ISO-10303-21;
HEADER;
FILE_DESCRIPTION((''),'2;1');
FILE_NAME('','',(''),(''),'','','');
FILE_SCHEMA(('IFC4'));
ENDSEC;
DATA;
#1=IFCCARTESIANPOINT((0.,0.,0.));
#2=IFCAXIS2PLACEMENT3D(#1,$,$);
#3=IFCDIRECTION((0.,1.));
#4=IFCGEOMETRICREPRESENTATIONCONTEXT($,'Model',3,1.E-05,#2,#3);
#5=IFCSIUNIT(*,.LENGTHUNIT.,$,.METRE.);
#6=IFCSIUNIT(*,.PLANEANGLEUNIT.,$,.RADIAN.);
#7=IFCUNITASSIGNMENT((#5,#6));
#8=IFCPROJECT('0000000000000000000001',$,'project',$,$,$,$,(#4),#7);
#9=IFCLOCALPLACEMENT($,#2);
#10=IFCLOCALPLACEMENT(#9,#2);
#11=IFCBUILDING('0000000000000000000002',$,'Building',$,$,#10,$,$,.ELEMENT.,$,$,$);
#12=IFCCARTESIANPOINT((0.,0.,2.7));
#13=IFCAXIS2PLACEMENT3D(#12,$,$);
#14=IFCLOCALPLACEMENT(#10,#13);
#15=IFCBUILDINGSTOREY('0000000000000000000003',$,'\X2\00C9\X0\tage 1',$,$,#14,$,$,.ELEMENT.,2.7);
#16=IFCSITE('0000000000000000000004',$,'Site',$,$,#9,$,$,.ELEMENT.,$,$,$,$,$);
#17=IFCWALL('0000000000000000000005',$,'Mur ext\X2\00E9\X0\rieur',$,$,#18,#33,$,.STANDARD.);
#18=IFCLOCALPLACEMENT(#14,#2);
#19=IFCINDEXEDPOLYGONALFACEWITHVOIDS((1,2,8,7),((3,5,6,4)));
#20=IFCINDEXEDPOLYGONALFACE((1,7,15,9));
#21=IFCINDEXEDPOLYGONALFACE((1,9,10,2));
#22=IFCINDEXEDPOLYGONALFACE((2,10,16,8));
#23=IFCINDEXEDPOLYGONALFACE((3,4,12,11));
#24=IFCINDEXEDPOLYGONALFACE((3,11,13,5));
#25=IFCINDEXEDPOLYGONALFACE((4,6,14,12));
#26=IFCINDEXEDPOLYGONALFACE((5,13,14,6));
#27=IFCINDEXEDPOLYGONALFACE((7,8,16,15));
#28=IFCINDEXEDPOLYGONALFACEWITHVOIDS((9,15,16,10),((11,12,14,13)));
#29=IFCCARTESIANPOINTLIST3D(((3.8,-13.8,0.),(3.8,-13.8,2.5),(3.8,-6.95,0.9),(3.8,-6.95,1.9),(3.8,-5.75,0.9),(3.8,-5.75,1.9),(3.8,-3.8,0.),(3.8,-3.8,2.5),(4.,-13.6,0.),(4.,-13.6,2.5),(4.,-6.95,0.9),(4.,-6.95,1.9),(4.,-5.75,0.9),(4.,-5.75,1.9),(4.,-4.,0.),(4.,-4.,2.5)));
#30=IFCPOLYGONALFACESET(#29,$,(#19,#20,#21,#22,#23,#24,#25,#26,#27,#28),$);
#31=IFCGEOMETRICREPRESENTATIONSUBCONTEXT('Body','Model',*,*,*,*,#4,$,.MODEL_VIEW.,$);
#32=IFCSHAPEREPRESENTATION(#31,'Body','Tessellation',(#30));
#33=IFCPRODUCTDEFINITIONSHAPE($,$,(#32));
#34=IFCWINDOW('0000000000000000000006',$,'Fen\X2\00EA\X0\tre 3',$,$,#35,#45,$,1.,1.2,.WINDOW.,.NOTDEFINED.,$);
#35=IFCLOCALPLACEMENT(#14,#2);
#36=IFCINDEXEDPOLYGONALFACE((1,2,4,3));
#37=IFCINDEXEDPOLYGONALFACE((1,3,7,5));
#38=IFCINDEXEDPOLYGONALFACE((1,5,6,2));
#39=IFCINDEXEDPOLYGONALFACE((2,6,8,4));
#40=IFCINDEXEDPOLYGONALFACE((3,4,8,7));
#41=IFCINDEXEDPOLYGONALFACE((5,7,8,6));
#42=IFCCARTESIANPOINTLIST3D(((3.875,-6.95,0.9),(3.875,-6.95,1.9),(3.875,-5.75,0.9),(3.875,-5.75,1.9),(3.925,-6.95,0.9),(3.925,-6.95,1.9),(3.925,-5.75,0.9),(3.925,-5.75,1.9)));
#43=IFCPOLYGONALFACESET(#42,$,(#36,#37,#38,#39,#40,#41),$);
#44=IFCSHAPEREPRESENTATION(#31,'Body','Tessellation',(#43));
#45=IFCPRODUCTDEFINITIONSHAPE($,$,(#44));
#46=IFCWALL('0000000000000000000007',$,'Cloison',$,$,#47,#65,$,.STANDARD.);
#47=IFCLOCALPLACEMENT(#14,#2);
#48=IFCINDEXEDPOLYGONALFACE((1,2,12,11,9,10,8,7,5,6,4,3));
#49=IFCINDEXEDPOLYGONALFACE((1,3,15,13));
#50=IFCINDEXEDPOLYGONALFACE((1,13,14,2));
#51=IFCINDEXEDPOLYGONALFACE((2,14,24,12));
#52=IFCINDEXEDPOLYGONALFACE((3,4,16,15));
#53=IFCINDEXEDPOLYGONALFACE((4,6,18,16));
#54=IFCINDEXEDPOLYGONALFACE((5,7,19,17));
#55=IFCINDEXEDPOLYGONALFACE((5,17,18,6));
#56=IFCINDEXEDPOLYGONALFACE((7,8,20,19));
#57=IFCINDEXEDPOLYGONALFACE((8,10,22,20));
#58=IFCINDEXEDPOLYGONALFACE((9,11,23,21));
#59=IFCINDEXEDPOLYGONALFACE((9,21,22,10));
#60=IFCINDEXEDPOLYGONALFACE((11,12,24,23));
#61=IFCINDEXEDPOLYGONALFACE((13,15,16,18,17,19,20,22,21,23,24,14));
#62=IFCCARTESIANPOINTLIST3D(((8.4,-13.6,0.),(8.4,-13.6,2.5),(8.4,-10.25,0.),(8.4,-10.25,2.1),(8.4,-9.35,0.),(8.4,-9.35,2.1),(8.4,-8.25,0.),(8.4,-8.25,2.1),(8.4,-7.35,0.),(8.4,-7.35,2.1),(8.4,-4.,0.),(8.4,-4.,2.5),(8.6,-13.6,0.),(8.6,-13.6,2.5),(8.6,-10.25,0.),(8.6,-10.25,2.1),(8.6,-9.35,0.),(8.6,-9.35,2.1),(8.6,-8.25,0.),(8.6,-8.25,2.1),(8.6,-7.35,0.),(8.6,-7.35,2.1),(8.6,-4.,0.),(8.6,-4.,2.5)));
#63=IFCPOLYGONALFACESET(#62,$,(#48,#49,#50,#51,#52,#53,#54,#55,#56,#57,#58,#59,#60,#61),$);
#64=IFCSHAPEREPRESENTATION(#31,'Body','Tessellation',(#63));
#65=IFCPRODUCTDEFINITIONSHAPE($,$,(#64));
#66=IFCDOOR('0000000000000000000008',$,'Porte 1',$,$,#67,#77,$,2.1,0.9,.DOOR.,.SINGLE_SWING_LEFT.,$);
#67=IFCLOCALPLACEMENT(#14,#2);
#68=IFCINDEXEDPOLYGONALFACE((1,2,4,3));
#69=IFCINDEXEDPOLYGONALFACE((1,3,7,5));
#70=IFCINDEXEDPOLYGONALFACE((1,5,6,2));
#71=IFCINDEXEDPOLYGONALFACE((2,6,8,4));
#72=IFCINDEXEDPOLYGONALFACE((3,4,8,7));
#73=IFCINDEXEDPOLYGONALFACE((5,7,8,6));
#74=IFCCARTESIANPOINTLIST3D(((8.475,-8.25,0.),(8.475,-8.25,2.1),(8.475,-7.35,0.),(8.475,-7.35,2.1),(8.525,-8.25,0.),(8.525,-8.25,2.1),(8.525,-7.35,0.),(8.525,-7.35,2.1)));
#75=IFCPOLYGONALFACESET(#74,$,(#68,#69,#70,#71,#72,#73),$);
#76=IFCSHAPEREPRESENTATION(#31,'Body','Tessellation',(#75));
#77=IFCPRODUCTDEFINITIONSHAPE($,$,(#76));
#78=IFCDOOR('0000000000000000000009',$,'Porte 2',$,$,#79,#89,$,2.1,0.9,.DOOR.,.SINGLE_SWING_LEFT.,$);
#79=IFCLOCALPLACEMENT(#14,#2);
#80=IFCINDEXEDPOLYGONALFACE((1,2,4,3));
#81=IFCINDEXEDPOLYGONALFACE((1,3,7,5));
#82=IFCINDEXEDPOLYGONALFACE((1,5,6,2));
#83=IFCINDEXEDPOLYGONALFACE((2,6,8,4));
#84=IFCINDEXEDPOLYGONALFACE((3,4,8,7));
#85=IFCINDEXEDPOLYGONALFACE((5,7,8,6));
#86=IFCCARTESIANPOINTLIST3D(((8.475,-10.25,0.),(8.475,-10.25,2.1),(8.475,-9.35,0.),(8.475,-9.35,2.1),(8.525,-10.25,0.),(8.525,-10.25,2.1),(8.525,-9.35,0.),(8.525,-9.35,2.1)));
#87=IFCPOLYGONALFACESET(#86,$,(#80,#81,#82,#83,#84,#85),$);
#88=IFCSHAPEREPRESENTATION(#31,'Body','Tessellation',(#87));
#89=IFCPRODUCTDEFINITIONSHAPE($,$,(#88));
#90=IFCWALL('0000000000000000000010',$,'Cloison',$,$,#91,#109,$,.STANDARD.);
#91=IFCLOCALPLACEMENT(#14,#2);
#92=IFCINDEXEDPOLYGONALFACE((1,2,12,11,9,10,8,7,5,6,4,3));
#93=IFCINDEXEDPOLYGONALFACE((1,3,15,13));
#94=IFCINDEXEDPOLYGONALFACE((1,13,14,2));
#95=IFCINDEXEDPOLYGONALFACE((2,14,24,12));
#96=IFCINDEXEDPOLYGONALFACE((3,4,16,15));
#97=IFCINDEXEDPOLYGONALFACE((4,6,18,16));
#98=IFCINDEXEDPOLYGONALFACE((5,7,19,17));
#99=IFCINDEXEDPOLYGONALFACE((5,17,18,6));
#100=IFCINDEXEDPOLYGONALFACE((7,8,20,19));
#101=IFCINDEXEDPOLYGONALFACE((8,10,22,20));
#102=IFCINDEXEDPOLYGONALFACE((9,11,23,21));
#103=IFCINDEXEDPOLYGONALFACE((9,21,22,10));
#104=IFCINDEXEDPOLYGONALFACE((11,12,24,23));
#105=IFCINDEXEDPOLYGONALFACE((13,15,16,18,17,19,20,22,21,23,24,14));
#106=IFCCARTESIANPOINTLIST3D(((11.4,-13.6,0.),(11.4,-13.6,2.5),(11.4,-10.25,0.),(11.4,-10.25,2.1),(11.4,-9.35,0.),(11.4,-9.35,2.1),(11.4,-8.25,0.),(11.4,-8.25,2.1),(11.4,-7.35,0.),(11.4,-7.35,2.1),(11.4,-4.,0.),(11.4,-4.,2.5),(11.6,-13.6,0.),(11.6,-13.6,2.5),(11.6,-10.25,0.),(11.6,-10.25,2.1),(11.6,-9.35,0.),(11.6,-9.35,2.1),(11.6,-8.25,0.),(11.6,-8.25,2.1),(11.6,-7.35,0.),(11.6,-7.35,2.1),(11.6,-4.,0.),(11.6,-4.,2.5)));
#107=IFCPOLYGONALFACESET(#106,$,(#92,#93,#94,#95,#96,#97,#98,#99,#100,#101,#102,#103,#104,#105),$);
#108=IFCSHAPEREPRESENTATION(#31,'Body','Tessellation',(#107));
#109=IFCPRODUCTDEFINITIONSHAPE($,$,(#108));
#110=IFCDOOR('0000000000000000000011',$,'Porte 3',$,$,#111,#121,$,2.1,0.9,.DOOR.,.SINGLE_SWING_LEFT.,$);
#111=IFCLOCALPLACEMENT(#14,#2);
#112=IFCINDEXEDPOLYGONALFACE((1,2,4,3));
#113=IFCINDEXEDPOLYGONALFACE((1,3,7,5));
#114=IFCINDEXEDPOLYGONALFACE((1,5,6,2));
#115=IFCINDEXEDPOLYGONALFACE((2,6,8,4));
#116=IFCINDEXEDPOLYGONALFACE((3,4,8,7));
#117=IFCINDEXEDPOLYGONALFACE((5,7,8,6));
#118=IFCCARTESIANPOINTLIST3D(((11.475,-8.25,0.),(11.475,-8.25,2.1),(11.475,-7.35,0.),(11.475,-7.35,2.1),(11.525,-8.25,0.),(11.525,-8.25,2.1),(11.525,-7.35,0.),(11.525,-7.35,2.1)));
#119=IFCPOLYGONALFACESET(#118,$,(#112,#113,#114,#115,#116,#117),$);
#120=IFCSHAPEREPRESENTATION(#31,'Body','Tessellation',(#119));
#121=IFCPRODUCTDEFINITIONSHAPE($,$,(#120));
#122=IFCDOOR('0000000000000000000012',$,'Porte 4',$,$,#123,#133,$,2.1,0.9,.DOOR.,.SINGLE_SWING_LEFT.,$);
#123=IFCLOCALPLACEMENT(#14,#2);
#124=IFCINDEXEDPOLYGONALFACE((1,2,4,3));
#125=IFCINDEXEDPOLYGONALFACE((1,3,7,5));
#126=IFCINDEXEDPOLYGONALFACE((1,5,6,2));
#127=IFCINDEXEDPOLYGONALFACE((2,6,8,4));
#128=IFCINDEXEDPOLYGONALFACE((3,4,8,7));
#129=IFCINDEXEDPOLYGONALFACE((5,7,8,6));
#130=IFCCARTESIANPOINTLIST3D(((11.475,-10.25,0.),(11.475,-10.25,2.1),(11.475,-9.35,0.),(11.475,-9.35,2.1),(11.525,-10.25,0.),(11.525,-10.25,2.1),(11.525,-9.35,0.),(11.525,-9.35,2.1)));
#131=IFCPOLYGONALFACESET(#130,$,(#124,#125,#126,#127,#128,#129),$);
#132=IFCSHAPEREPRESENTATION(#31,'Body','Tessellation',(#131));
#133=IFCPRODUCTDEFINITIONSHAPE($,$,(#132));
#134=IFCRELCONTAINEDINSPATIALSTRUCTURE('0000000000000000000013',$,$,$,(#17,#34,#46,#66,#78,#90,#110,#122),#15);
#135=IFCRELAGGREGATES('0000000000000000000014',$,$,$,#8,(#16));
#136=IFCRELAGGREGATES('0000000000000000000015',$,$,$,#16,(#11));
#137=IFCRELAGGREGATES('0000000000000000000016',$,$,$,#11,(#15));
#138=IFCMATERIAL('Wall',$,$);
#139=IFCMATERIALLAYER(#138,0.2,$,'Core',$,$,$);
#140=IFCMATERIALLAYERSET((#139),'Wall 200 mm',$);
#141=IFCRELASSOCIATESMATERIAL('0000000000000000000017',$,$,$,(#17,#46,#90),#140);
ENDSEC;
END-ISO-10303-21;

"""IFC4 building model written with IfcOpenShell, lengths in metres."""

from ifc_helpers import new_model, si_unit, direction, frame, origin, origin_2d, place, context, subcontext, project, spatial, polyline, rectangle, outline, extrude, material, layer, layer_set, layer_usage, element, fill, save


model = new_model("IFC4")

# Units and contexts
model_context = context("Model", 3, precision=1e-05, world=origin(), true_north=direction((0.0, 1.0)))
body_context = subcontext(model_context, "Body", "Model", "MODEL_VIEW")
ifc_project = project(units=[si_unit("LENGTHUNIT", "METRE"), si_unit("PLANEANGLEUNIT", "RADIAN")], contexts=[model_context])

# Site, building, storey
site_placement = place(None, origin())
site = spatial("IfcSite", under=ifc_project, at=site_placement, Name="Site", CompositionType="ELEMENT")
building_placement = place(site_placement, origin())
building = spatial("IfcBuilding", under=site, at=building_placement, Name="Building", CompositionType="ELEMENT")
storey_placement = place(building_placement, frame((0.0, 0.0, 2.7)))
storey = spatial("IfcBuildingStorey", under=building, at=storey_placement, Name="Étage 1", CompositionType="ELEMENT", Elevation=2.7)

# Shared definitions
ifc_material = material(Name="Wall")
ifc_layer = layer(ifc_material, 0.2, Name="Core")
ifc_layer_set = layer_set([ifc_layer], Name="Wall 200 mm")
ifc_layer_usage = layer_usage(ifc_layer_set, "AXIS2", "POSITIVE", -0.1)

# Wall, opening, window
wall_1_placement = place(storey_placement, frame((3.9, -13.7, 0.0), z_axis=(0.0, 0.0, 1.0), x_axis=(0.0, 1.0, 0.0)))
wall_1 = element("IfcWall", 1, at=wall_1_placement, inside=storey, material=ifc_layer_usage, Name="Mur extérieur", PredefinedType="STANDARD", context=body_context, shape_type="SweptSolid", body=[
    extrude(outline(polyline([(0.0, 0.0), (0.1, -0.1), (9.7, -0.1), (9.8, 0.0), (9.9, 0.1), (-0.1, 0.1), (0.0, 0.0)])), origin(), (0.0, 0.0, 1.0), 2.5),
])
opening_1_placement = place(wall_1_placement, frame((7.35, 0.0, 0.9)))
opening_1 = element("IfcOpeningElement", 2, at=opening_1_placement, cuts=wall_1, PredefinedType="OPENING", context=body_context, shape_type="SweptSolid", body=[
    extrude(rectangle(XDim=1.2, YDim=0.4, at=origin_2d()), origin(), (0.0, 0.0, 1.0), 1.0),
])
window_1_placement = place(opening_1_placement, origin())
window_1 = element("IfcWindow", 3, at=window_1_placement, inside=storey, Name="Fenêtre 3", OverallHeight=1.0, OverallWidth=1.2, PartitioningType="NOTDEFINED", PredefinedType="WINDOW", context=body_context, shape_type="SweptSolid", body=[
    extrude(rectangle(XDim=1.2, YDim=0.05, at=origin_2d()), origin(), (0.0, 0.0, 1.0), 1.0),
])
fill(opening_1, window_1)

# Walls, openings, doors
wall_2_placement = place(storey_placement, frame((8.5, -3.9, 0.0), z_axis=(0.0, 0.0, 1.0), x_axis=(0.0, -1.0, 0.0)))
wall_2 = element("IfcWall", 4, at=wall_2_placement, inside=storey, material=ifc_layer_usage, Name="Cloison", PredefinedType="STANDARD", context=body_context, shape_type="SweptSolid", body=[
    extrude(outline(polyline([(0.1, 0.0), (0.1, -0.1), (9.7, -0.1), (9.7, 0.0), (9.7, 0.1), (0.1, 0.1), (0.1, 0.0)])), origin(), (0.0, 0.0, 1.0), 2.5),
])
opening_2_placement = place(wall_2_placement, frame((3.9, 0.0, 0.0)))
opening_2 = element("IfcOpeningElement", 5, at=opening_2_placement, cuts=wall_2, PredefinedType="OPENING", context=body_context, shape_type="SweptSolid", body=[
    extrude(rectangle(XDim=0.9, YDim=0.4, at=origin_2d()), origin(), (0.0, 0.0, 1.0), 2.1),
])
opening_3_placement = place(wall_2_placement, frame((5.9, 0.0, 0.0)))
opening_3 = element("IfcOpeningElement", 6, at=opening_3_placement, cuts=wall_2, PredefinedType="OPENING", context=body_context, shape_type="SweptSolid", body=[
    extrude(rectangle(XDim=0.9, YDim=0.4, at=origin_2d()), origin(), (0.0, 0.0, 1.0), 2.1),
])
door_1_placement = place(opening_2_placement, origin())
door_1 = element("IfcDoor", 7, at=door_1_placement, inside=storey, Name="Porte 1", OperationType="SINGLE_SWING_LEFT", OverallHeight=2.1, OverallWidth=0.9, PredefinedType="DOOR", context=body_context, shape_type="SweptSolid", body=[
    extrude(rectangle(XDim=0.9, YDim=0.05, at=origin_2d()), origin(), (0.0, 0.0, 1.0), 2.1),
])
fill(opening_2, door_1)
door_2_placement = place(opening_3_placement, origin())
door_2 = element("IfcDoor", 8, at=door_2_placement, inside=storey, Name="Porte 2", OperationType="SINGLE_SWING_LEFT", OverallHeight=2.1, OverallWidth=0.9, PredefinedType="DOOR", context=body_context, shape_type="SweptSolid", body=[
    extrude(rectangle(XDim=0.9, YDim=0.05, at=origin_2d()), origin(), (0.0, 0.0, 1.0), 2.1),
])
fill(opening_3, door_2)
wall_3_placement = place(storey_placement, frame((11.5, -3.9, 0.0), z_axis=(0.0, 0.0, 1.0), x_axis=(0.0, -1.0, 0.0)))
wall_3 = element("IfcWall", 9, at=wall_3_placement, inside=storey, material=ifc_layer_usage, Name="Cloison", PredefinedType="STANDARD", context=body_context, shape_type="SweptSolid", body=[
    extrude(outline(polyline([(0.1, 0.0), (0.1, -0.1), (9.7, -0.1), (9.7, 0.0), (9.7, 0.1), (0.1, 0.1), (0.1, 0.0)])), origin(), (0.0, 0.0, 1.0), 2.5),
])
opening_4_placement = place(wall_3_placement, frame((3.9, 0.0, 0.0)))
opening_4 = element("IfcOpeningElement", 10, at=opening_4_placement, cuts=wall_3, PredefinedType="OPENING", context=body_context, shape_type="SweptSolid", body=[
    extrude(rectangle(XDim=0.9, YDim=0.4, at=origin_2d()), origin(), (0.0, 0.0, 1.0), 2.1),
])
opening_5_placement = place(wall_3_placement, frame((5.9, 0.0, 0.0)))
opening_5 = element("IfcOpeningElement", 11, at=opening_5_placement, cuts=wall_3, PredefinedType="OPENING", context=body_context, shape_type="SweptSolid", body=[
    extrude(rectangle(XDim=0.9, YDim=0.4, at=origin_2d()), origin(), (0.0, 0.0, 1.0), 2.1),
])
door_3_placement = place(opening_4_placement, origin())
door_3 = element("IfcDoor", 12, at=door_3_placement, inside=storey, Name="Porte 3", OperationType="SINGLE_SWING_LEFT", OverallHeight=2.1, OverallWidth=0.9, PredefinedType="DOOR", context=body_context, shape_type="SweptSolid", body=[
    extrude(rectangle(XDim=0.9, YDim=0.05, at=origin_2d()), origin(), (0.0, 0.0, 1.0), 2.1),
])
fill(opening_4, door_3)
door_4_placement = place(opening_5_placement, origin())
door_4 = element("IfcDoor", 13, at=door_4_placement, inside=storey, Name="Porte 4", OperationType="SINGLE_SWING_LEFT", OverallHeight=2.1, OverallWidth=0.9, PredefinedType="DOOR", context=body_context, shape_type="SweptSolid", body=[
    extrude(rectangle(XDim=0.9, YDim=0.05, at=origin_2d()), origin(), (0.0, 0.0, 1.0), 2.1),
])
fill(opening_5, door_4)

save(model, "model.ifc")
